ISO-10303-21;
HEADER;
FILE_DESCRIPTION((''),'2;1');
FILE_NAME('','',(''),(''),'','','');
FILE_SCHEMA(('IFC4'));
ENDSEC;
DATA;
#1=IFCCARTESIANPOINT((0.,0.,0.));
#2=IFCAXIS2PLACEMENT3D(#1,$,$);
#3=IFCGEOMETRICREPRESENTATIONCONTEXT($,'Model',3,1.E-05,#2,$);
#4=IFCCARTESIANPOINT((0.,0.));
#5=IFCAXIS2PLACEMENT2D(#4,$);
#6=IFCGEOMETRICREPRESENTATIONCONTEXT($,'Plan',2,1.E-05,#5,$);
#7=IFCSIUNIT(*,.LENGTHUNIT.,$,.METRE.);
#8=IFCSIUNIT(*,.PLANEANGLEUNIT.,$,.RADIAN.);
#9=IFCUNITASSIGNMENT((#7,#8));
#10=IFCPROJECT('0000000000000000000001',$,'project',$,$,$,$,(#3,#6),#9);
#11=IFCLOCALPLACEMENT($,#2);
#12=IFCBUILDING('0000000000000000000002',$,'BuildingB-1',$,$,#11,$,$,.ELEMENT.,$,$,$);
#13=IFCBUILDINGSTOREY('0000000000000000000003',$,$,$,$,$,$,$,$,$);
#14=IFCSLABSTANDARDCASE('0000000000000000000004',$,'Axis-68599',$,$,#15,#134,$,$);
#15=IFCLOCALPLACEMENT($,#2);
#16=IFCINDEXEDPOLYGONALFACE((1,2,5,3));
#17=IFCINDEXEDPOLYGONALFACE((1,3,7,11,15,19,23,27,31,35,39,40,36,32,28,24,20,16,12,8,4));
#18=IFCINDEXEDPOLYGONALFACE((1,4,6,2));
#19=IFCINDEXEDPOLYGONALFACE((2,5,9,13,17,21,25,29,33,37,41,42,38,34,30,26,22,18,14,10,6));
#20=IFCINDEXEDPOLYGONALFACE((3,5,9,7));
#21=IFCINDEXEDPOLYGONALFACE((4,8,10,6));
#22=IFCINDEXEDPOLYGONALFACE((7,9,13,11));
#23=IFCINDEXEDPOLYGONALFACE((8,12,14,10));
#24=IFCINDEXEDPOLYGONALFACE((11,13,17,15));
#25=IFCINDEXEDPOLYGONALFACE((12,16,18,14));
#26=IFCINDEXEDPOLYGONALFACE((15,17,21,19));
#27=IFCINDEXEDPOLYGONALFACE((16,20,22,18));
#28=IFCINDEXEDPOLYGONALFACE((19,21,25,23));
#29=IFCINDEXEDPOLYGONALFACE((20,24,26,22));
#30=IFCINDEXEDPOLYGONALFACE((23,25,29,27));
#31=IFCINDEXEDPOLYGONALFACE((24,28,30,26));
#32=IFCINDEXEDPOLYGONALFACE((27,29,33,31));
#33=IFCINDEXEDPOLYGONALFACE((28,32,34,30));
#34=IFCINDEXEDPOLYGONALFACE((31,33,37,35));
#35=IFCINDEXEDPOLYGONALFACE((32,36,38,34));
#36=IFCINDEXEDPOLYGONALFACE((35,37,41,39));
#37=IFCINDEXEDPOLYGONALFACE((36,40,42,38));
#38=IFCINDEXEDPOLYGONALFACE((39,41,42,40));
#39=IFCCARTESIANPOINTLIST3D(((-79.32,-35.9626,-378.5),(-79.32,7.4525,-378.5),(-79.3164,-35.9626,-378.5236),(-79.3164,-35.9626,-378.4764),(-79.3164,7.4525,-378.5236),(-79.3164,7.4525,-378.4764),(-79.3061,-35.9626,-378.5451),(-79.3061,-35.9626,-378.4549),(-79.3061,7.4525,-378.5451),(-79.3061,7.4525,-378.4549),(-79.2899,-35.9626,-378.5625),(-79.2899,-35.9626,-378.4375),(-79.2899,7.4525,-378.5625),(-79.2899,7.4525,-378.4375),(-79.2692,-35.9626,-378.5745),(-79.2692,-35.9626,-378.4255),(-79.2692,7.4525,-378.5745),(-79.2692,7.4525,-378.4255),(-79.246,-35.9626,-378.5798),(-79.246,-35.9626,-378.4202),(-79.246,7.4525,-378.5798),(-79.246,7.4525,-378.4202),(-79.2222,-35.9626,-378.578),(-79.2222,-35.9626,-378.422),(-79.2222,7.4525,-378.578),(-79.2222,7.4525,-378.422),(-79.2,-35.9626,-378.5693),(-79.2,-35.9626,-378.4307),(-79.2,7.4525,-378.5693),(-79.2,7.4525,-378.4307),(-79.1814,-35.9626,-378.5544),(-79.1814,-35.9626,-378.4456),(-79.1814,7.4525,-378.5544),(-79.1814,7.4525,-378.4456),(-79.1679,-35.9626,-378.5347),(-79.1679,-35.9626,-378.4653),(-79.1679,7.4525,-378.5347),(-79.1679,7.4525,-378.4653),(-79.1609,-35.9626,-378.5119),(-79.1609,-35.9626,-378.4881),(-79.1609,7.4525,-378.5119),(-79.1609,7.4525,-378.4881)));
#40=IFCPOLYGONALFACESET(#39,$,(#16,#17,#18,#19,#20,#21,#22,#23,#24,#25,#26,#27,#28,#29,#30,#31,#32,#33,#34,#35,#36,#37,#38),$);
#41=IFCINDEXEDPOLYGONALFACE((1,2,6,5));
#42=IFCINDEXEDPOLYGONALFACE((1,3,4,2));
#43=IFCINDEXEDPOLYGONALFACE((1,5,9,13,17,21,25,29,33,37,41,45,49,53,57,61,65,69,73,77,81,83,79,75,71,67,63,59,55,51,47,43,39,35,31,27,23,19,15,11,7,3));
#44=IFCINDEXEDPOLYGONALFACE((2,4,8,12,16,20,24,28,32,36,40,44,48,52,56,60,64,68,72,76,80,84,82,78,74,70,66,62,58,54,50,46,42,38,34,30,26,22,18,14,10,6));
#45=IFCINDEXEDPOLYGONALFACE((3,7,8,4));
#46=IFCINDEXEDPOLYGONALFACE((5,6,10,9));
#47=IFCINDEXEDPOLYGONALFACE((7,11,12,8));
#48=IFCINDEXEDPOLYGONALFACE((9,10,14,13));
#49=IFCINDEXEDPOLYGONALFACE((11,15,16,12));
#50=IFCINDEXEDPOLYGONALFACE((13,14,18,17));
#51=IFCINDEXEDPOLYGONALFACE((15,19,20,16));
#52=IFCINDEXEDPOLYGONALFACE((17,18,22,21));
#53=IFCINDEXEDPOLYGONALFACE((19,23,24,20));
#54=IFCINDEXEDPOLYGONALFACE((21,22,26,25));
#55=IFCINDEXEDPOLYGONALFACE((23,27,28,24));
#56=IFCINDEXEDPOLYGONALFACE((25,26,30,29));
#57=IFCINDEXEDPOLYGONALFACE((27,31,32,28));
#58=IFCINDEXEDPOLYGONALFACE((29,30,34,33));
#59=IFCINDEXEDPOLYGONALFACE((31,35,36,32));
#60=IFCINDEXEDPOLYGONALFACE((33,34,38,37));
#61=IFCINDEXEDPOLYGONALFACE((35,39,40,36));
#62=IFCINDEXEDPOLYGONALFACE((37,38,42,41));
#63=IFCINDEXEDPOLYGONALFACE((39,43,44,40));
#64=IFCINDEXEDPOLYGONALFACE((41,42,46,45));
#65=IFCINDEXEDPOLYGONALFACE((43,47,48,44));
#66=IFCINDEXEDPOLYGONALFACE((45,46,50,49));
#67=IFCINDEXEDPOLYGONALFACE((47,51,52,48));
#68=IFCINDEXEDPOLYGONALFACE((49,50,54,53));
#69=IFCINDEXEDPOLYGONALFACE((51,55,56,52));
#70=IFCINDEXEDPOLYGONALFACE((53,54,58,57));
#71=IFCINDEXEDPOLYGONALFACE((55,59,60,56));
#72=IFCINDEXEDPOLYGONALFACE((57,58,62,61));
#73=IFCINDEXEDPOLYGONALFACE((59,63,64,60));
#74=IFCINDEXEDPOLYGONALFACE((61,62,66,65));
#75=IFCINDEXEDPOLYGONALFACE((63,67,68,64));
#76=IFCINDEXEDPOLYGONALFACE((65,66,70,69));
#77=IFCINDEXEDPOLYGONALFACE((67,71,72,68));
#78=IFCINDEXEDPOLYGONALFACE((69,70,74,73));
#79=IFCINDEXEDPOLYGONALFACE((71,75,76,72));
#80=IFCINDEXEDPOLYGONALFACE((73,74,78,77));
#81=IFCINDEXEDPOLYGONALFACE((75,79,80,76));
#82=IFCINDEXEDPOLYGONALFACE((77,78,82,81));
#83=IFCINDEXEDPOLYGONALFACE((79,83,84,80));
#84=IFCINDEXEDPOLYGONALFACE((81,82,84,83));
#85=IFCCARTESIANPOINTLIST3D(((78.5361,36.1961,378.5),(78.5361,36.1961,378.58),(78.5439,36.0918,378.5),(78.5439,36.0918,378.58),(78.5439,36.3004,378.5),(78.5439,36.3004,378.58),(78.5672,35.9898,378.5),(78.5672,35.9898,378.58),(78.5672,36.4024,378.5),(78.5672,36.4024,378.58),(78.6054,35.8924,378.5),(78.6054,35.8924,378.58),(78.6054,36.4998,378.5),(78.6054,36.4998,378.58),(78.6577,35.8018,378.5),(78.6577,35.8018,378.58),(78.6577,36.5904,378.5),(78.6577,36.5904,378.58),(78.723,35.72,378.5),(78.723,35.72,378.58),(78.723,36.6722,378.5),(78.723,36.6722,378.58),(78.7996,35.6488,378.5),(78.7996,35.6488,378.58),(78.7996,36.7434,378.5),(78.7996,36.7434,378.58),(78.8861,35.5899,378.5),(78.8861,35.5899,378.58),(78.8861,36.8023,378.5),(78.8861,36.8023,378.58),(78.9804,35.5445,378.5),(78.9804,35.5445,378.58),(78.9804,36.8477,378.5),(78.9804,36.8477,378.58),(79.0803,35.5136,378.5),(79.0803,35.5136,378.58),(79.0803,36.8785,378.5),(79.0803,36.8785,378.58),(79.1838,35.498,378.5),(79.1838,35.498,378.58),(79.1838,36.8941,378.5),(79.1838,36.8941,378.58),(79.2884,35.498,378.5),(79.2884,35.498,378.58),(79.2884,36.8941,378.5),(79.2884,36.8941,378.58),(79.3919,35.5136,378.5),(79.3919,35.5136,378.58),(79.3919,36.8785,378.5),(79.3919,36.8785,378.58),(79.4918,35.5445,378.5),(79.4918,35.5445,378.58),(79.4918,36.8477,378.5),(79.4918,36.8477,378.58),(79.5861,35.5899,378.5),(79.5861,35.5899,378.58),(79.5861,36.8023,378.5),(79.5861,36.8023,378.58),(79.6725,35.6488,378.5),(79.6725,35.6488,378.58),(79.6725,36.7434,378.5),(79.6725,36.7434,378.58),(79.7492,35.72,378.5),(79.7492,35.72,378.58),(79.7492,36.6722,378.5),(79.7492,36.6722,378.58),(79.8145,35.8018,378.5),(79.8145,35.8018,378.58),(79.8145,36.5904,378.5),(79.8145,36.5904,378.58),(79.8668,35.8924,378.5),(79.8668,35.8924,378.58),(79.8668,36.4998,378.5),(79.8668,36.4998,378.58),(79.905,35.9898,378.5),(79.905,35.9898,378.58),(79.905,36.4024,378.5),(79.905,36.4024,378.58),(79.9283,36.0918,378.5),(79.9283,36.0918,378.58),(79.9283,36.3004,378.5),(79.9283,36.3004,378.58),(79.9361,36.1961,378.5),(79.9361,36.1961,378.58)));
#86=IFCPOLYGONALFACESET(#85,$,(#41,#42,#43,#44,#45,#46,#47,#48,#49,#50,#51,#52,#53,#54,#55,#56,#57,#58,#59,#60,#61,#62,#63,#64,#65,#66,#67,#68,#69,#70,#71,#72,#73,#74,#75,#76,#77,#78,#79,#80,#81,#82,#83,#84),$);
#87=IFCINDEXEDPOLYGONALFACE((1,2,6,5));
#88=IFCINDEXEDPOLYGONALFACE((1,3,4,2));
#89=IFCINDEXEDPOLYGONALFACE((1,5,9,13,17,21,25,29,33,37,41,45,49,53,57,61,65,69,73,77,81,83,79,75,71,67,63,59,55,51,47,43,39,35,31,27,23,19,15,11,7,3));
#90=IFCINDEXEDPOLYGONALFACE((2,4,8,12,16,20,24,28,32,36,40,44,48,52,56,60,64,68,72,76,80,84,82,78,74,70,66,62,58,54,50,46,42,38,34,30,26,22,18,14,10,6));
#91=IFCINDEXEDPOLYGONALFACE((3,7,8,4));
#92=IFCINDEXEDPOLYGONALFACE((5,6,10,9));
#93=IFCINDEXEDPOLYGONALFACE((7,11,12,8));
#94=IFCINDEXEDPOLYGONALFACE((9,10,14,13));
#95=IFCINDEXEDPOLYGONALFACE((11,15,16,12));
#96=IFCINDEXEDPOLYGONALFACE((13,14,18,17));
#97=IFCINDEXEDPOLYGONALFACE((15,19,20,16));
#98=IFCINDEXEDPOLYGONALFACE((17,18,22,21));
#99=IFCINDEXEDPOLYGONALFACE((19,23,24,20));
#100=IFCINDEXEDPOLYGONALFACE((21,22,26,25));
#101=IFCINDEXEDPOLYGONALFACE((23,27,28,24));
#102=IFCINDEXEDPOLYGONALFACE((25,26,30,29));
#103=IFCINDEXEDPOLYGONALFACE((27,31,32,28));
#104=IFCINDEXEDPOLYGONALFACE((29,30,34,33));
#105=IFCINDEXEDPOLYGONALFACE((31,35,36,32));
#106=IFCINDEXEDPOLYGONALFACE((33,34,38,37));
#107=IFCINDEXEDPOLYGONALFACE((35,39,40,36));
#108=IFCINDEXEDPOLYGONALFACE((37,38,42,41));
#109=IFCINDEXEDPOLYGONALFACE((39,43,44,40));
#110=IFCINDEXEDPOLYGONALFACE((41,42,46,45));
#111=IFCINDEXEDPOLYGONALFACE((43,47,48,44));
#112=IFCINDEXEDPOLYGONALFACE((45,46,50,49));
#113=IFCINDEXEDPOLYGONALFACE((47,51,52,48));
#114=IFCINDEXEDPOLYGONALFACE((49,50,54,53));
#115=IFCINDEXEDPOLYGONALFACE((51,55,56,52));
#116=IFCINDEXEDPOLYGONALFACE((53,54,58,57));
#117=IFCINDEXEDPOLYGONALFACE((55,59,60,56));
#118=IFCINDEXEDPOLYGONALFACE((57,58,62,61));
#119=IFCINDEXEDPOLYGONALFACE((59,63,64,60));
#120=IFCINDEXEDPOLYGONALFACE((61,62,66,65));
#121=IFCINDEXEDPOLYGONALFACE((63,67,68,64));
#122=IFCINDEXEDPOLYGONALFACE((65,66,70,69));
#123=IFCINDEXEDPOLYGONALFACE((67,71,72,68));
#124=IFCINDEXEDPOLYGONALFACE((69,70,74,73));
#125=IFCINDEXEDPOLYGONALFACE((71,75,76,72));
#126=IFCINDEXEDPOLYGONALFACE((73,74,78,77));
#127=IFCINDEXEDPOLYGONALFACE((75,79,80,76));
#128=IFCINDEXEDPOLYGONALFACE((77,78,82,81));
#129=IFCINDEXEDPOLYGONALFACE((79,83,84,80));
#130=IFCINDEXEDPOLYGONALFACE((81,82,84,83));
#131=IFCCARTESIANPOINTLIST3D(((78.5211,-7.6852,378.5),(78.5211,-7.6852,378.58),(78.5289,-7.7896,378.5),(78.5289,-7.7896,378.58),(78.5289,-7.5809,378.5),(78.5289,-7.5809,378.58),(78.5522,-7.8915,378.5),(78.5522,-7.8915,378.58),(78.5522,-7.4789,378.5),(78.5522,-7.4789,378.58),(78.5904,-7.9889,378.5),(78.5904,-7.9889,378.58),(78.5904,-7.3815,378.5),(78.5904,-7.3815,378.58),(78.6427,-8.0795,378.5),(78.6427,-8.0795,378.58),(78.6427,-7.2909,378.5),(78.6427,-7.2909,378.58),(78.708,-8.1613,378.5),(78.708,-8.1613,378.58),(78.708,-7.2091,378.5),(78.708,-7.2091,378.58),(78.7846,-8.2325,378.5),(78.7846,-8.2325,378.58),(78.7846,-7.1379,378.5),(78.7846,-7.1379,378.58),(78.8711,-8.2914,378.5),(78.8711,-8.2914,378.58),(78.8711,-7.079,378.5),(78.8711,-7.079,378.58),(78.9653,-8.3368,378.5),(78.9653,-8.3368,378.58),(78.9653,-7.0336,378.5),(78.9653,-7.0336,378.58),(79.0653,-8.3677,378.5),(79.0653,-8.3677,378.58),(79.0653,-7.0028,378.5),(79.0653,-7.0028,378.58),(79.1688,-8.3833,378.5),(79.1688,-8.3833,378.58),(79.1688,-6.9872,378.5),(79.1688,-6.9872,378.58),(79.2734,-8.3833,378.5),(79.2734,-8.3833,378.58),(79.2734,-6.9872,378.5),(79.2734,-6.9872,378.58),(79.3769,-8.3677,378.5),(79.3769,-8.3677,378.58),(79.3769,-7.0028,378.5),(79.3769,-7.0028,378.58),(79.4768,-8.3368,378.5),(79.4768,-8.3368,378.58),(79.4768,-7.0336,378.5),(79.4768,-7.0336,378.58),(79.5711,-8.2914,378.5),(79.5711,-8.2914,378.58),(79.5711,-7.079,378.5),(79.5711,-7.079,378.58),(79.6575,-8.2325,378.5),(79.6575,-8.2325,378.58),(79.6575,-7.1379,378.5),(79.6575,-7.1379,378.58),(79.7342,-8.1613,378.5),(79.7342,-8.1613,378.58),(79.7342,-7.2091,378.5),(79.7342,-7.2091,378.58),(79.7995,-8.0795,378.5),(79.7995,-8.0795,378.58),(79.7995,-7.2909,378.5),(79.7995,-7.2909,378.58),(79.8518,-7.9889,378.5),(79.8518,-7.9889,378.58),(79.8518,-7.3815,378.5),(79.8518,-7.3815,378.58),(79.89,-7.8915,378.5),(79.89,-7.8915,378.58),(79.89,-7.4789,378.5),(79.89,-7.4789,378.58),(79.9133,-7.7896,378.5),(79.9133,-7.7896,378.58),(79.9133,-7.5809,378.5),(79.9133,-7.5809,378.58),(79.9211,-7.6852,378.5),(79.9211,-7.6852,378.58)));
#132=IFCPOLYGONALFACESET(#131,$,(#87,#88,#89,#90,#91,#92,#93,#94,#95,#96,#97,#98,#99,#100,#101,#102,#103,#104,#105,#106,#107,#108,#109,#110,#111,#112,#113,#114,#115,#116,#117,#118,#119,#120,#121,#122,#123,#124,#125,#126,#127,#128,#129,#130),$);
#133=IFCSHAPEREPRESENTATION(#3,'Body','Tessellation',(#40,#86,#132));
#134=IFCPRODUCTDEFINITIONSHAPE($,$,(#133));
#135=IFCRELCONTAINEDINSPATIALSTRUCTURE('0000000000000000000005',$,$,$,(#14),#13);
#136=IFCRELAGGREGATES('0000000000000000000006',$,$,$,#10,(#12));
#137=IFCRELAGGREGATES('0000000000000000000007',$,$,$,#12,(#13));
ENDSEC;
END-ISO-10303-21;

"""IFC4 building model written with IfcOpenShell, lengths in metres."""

from ifc_helpers import new_model, entity, si_unit, frame, origin, origin_2d, place, context, project, spatial, circle, extrude, element, save


model = new_model("IFC4")

# Units and contexts
model_context = context("Model", 3, precision=1e-05, world=origin())
plan_context = context("Plan", 2, precision=1e-05, world=origin_2d())
ifc_project = project(units=[si_unit("LENGTHUNIT", "METRE"), si_unit("PLANEANGLEUNIT", "RADIAN")], contexts=[model_context, plan_context])

# Building, storey
building_placement = place(None, origin())
building = spatial("IfcBuilding", under=ifc_project, at=building_placement, Name="BuildingB-1", CompositionType="ELEMENT")
storey = spatial("IfcBuildingStorey", under=building)

# Slab
element("IfcSlabStandardCase", 1, inside=storey, Name="Axis-68599", context=model_context, shape_type="AdvancedSweptSolid", body=[
    entity("IfcSurfaceCurveSweptAreaSolid", entity("IfcCircleProfileDef", "AREA", None, None, 0.08), None, entity("IfcPolyline", [entity("IfcCartesianPoint", [79.24, 35.9626, 378.5]), entity("IfcCartesianPoint", [79.24, -7.4525, 378.5])]), None, None, entity("IfcPlane", entity("IfcAxis2Placement3D", entity("IfcCartesianPoint", [79.24, 35.9626, 378.5]), entity("IfcDirection", [0.0, 0.0, 1.0]), entity("IfcDirection", [1.0, 0.0, 0.0])))),
    extrude(circle(Radius=0.7), frame((79.2361, 36.1961, 378.5)), (0.0, 0.0, 1.0), 0.08),
    extrude(circle(Radius=0.7), frame((79.2211, -7.6852, 378.5)), (0.0, 0.0, 1.0), 0.08),
])

save(model, "model.ifc")
